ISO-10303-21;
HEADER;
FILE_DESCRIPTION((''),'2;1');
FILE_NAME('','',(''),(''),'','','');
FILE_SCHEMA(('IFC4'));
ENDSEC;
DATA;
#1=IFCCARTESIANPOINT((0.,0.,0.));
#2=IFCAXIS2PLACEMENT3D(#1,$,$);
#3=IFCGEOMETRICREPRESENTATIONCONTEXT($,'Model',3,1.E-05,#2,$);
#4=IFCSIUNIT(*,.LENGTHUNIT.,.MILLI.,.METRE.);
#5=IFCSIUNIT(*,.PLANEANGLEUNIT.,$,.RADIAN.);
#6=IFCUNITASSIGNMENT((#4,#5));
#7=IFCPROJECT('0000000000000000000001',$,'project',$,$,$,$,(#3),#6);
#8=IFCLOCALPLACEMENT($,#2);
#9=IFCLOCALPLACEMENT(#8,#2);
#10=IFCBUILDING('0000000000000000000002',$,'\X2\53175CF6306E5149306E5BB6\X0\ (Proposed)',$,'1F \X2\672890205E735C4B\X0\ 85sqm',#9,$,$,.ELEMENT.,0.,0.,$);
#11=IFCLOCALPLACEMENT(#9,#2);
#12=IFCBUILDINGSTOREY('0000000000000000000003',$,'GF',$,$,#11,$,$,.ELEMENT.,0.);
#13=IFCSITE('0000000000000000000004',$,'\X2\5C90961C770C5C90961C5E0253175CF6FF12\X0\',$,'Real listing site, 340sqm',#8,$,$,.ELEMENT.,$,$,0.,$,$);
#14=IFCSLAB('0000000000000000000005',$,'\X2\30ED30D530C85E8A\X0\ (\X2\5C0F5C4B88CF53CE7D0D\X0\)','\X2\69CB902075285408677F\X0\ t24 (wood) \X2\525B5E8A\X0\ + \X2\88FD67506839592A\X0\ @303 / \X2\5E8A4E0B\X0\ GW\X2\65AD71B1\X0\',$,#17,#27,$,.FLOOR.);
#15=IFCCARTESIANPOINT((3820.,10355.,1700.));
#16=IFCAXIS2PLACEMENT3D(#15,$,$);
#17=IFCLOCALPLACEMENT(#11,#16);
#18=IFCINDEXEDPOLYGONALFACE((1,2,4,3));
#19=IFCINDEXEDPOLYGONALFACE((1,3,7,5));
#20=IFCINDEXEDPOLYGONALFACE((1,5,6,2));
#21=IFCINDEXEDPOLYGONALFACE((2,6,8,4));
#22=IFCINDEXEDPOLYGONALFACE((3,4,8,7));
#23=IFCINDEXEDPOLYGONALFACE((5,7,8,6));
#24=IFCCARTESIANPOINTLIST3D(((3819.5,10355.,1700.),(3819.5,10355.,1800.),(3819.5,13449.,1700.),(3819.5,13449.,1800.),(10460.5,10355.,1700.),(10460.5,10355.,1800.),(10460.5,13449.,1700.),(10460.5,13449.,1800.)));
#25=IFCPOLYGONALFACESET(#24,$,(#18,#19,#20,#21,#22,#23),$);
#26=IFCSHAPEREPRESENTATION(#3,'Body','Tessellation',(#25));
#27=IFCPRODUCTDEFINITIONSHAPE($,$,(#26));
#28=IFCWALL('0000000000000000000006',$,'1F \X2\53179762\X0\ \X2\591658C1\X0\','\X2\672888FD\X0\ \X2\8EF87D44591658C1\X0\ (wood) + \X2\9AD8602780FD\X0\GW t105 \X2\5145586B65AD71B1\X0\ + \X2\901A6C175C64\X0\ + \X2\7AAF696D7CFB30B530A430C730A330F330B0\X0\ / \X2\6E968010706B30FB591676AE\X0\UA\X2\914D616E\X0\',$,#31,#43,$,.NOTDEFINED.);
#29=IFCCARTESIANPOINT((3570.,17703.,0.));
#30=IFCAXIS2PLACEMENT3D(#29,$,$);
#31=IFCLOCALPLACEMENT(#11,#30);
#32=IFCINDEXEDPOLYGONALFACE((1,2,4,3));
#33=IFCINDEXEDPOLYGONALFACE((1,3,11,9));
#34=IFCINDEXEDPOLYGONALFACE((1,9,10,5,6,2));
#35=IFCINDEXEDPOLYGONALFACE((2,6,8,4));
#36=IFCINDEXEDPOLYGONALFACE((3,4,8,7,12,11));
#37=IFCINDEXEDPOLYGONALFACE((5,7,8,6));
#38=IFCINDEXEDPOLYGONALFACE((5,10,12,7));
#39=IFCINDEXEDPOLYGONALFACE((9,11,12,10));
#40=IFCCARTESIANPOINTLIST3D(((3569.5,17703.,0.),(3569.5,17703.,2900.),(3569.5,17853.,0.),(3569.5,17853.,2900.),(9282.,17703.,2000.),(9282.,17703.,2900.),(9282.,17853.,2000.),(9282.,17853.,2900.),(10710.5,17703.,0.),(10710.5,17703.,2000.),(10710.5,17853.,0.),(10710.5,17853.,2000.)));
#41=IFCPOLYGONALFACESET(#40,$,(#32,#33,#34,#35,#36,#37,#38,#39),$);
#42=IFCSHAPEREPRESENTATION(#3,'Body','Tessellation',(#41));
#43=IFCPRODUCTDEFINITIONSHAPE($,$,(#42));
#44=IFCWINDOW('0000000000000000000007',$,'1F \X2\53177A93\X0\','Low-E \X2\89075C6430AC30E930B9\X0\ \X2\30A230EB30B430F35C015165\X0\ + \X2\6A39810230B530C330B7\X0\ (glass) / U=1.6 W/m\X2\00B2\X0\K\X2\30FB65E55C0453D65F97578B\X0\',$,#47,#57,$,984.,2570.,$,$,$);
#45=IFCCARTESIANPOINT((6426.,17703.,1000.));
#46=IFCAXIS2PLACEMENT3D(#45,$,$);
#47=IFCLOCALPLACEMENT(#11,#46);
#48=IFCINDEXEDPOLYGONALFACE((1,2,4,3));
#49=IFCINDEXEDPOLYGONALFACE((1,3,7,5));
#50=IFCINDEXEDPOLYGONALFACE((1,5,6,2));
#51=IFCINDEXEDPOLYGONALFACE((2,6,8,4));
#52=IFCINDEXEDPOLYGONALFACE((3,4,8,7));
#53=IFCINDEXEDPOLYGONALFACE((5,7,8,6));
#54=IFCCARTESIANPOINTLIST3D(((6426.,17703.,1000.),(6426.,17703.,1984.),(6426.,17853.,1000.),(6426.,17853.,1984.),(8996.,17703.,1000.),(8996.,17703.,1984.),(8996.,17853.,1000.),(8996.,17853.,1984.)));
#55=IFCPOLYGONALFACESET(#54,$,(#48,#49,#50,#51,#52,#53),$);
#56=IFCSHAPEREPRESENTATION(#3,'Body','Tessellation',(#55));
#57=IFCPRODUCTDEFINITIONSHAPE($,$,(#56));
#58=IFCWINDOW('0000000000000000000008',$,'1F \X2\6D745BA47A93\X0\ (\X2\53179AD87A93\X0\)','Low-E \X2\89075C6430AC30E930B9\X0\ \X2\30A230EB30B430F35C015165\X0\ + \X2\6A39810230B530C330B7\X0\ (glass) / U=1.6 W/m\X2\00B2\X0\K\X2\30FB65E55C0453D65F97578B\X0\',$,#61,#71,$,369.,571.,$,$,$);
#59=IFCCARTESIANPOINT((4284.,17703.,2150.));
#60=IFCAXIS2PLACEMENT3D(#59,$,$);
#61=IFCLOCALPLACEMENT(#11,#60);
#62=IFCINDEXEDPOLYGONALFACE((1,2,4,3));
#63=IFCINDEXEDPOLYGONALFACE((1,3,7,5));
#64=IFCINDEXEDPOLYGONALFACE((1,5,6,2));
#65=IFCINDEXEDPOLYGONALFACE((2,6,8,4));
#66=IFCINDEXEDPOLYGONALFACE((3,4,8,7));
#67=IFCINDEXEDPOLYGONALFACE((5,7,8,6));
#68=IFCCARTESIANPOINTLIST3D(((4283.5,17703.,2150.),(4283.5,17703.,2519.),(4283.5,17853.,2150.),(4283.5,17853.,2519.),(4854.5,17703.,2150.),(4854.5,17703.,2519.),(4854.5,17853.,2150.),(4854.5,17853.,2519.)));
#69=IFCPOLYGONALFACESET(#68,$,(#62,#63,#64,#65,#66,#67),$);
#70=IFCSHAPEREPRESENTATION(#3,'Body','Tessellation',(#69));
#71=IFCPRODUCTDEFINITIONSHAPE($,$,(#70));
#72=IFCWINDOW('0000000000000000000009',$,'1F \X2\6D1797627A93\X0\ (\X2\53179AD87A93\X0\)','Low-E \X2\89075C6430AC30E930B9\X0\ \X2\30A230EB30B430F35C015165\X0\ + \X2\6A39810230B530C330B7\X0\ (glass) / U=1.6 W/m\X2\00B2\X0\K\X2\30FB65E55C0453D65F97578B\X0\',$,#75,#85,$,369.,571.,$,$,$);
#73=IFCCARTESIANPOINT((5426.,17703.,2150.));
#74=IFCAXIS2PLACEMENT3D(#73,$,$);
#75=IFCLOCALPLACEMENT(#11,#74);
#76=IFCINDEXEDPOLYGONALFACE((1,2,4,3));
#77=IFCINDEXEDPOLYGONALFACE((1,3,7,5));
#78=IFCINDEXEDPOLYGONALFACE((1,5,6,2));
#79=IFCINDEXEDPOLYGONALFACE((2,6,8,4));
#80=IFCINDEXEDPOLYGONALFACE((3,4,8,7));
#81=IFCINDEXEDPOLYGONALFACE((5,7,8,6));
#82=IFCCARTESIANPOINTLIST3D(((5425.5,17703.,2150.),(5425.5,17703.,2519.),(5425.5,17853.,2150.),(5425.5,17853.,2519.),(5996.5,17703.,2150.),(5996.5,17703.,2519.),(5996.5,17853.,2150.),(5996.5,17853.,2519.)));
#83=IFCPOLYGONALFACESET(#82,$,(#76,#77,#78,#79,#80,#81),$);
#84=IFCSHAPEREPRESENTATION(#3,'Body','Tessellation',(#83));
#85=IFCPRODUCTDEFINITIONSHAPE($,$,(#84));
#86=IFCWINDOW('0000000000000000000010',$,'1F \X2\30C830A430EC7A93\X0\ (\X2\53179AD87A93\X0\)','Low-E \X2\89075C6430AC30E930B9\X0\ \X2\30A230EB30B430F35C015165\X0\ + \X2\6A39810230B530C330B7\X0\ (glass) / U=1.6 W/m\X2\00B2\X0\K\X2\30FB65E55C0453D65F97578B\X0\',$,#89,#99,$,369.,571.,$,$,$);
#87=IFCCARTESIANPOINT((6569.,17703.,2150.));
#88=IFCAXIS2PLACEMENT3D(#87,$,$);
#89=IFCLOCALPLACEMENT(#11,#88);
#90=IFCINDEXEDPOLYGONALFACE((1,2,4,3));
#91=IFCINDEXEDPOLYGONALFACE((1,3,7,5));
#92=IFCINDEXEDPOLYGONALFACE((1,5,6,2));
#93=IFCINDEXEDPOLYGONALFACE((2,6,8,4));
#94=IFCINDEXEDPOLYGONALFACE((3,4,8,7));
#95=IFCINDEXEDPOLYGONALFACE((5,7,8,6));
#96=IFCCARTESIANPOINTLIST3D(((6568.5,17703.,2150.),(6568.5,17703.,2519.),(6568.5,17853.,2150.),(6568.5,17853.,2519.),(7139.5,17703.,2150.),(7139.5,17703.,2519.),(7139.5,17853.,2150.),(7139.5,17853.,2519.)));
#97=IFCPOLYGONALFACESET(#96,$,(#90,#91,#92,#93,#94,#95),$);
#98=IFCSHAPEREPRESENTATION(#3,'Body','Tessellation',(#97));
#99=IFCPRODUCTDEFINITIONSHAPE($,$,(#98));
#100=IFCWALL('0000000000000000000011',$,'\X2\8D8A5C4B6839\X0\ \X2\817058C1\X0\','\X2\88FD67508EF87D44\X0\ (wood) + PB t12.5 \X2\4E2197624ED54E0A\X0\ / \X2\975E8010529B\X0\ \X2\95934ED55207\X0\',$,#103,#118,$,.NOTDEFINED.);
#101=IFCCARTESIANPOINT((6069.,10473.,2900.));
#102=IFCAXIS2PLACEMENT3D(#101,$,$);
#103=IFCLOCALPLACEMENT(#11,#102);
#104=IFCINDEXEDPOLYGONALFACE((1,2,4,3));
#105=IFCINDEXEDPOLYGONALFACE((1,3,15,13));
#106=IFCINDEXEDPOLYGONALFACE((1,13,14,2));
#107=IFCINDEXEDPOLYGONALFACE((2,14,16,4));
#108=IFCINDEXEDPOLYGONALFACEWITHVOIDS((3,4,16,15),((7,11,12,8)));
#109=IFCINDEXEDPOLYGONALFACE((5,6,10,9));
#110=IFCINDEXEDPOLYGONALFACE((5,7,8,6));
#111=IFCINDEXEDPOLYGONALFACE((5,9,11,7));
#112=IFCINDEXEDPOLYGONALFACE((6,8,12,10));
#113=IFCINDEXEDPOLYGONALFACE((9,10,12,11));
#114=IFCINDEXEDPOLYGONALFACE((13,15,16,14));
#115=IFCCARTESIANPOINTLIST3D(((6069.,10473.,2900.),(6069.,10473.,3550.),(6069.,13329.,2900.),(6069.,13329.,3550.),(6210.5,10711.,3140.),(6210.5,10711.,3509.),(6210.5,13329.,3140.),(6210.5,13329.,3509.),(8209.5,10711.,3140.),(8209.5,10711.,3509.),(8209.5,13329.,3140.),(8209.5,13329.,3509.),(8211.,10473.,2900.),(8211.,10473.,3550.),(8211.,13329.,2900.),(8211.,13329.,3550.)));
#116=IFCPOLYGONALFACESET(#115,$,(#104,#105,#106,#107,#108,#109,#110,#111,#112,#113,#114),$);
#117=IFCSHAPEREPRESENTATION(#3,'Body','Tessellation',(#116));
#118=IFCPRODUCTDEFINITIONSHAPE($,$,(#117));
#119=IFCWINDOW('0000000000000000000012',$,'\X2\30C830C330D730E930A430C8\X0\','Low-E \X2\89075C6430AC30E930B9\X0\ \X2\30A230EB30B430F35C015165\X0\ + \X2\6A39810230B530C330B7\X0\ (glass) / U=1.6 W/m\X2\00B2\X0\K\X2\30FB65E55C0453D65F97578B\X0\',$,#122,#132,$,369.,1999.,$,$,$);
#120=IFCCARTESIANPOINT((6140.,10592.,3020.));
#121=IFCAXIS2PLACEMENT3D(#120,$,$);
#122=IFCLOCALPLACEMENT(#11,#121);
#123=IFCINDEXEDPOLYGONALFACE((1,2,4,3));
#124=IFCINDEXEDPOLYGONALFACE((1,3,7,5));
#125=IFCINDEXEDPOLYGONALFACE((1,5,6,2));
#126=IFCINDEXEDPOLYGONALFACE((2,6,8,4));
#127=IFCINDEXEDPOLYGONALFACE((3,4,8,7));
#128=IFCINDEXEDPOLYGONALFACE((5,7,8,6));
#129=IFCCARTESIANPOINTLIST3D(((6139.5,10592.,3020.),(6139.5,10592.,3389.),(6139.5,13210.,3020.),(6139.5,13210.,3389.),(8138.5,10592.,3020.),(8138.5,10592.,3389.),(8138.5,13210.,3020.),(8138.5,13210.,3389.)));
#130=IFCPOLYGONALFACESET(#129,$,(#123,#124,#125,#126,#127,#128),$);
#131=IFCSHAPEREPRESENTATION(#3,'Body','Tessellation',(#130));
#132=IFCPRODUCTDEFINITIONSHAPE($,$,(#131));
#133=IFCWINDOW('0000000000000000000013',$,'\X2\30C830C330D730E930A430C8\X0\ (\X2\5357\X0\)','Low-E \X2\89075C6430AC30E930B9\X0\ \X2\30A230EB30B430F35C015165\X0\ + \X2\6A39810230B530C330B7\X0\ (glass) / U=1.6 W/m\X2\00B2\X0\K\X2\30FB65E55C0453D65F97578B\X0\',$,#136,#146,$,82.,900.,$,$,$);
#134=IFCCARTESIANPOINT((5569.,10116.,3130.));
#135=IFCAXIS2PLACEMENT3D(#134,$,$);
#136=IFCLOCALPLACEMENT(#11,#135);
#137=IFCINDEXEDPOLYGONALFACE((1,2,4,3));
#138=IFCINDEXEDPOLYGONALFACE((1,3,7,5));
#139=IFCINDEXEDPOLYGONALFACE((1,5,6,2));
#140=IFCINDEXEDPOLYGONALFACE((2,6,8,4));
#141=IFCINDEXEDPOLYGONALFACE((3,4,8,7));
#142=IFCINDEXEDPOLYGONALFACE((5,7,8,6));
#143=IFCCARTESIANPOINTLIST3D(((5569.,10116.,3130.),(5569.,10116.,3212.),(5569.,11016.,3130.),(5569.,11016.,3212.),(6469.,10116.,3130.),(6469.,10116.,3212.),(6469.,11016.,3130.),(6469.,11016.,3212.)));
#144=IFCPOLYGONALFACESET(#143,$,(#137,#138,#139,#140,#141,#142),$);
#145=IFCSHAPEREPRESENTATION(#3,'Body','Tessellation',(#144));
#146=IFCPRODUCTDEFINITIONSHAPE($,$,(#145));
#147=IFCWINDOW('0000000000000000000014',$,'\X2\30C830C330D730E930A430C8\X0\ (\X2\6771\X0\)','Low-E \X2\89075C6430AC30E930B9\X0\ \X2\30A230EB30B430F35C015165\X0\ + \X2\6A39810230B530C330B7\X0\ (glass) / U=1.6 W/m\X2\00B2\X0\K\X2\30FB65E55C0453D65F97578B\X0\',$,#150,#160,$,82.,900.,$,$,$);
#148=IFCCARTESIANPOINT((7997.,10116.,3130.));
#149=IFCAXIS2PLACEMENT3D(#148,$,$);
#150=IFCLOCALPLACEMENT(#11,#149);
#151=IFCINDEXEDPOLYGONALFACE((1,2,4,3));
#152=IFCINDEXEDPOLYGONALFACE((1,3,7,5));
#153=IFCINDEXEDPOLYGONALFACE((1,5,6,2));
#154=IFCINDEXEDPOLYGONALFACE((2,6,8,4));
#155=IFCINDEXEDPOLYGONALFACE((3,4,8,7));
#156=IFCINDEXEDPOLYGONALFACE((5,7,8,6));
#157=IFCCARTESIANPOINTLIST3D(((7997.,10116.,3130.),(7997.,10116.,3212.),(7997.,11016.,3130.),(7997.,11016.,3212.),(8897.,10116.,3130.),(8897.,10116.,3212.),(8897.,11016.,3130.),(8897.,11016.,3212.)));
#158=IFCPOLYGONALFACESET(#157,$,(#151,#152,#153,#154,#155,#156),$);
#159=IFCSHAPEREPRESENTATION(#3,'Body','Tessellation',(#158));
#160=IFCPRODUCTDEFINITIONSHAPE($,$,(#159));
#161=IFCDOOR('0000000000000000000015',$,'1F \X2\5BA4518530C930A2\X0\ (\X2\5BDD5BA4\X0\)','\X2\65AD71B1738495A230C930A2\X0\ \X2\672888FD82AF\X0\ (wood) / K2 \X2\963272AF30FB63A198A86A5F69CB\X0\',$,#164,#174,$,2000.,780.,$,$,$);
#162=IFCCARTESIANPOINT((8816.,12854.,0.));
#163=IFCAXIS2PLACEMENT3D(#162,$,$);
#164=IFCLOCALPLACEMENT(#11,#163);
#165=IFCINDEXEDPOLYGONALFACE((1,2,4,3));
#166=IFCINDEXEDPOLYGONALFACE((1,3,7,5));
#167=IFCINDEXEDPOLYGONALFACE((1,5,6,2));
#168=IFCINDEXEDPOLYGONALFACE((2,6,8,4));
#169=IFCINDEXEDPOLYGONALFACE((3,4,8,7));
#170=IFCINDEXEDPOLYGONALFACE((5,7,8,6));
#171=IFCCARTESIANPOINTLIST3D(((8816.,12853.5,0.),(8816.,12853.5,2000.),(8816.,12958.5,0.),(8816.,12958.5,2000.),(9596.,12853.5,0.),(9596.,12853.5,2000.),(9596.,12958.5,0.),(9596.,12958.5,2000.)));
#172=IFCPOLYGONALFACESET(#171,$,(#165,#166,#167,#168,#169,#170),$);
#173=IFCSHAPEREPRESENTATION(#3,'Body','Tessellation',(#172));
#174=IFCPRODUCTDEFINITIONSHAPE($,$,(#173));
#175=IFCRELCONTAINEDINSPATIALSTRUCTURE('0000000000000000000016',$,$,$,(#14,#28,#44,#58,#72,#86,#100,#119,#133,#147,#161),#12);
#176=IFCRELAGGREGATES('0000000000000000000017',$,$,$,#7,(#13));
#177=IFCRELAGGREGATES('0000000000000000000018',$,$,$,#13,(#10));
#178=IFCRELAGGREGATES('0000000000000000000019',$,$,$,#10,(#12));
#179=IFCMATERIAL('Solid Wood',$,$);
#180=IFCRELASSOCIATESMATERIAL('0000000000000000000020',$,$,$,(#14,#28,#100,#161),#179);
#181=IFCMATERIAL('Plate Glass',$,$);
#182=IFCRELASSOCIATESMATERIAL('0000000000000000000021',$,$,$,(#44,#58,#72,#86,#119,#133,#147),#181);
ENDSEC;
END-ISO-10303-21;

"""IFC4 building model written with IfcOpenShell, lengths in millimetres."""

from ifc_helpers import new_model, si_unit, frame, frame_2d, origin, place, context, project, spatial, rectangle, extrude, material, element, fill, save


model = new_model("IFC4")

# Units and contexts
model_context = context("Model", 3, precision=1e-05, world=origin())
ifc_project = project(units=[si_unit("LENGTHUNIT", "METRE", prefix="MILLI"), si_unit("PLANEANGLEUNIT", "RADIAN")], contexts=[model_context])

# Site, building, storey
site_placement = place(None, origin())
site = spatial("IfcSite", under=ifc_project, at=site_placement, Name="岐阜県岐阜市北島２", ObjectType="Real listing site, 340sqm", CompositionType="ELEMENT", RefElevation=0.0)
building_placement = place(site_placement, origin())
building = spatial("IfcBuilding", under=site, at=building_placement, Name="北島の光の家 (Proposed)", ObjectType="1F 木造平屋 85sqm", CompositionType="ELEMENT", ElevationOfRefHeight=0.0, ElevationOfTerrain=0.0)
storey_placement = place(building_placement, origin())
storey = spatial("IfcBuildingStorey", under=building, at=storey_placement, Name="GF", CompositionType="ELEMENT", Elevation=0.0)

# Slab
ifc_material_1 = material(Name="Solid Wood")
slab_placement = place(storey_placement, frame((3820.0, 10355.0, 1700.0)))
element("IfcSlab", 1, at=slab_placement, inside=storey, material=ifc_material_1, Name="ロフト床 (小屋裏収納)", Description="構造用合板 t24 (wood) 剛床 + 製材根太 @303 / 床下 GW断熱", PredefinedType="FLOOR", context=model_context, shape_type="SweptSolid", body=[
    extrude(rectangle(XDim=6641.0, YDim=3094.0, at=frame_2d((3320.0, 1547.0))), frame((3820.0, 10355.0, 1700.0)), (0.0, 0.0, 1.0), 100.0),
])

# Wall, openings, windows
wall_1_placement = place(storey_placement, frame((3570.0, 17703.0, 0.0)))
wall_1 = element("IfcWall", 2, at=wall_1_placement, inside=storey, material=ifc_material_1, Name="1F 北面 外壁", Description="木製 軸組外壁 (wood) + 高性能GW t105 充填断熱 + 通気層 + 窯業系サイディング / 準耐火・外皮UA配慮", PredefinedType="NOTDEFINED", context=model_context, shape_type="SweptSolid", body=[
    extrude(rectangle(XDim=7141.0, YDim=150.0, at=frame_2d((3570.0, 75.0))), frame((3570.0, 17703.0, 0.0)), (0.0, 0.0, 1.0), 2900.0),
])
opening_1_placement = place(storey_placement, frame((6426.0, 17703.0, 1000.0)))
opening_1 = element("IfcOpeningElement", 3, at=opening_1_placement, cuts=wall_1, PredefinedType="NOTDEFINED", context=model_context, shape_type="SweptSolid", body=[
    extrude(rectangle(XDim=2570.0, YDim=150.0, at=frame_2d((1285.0, 75.0))), frame((6426.0, 17703.0, 1000.0)), (0.0, 0.0, 1.0), 984.0),
])
opening_2_placement = place(storey_placement, frame((4284.0, 17703.0, 2150.0)))
opening_2 = element("IfcOpeningElement", 4, at=opening_2_placement, cuts=wall_1, PredefinedType="NOTDEFINED", context=model_context, shape_type="SweptSolid", body=[
    extrude(rectangle(XDim=571.0, YDim=150.0, at=frame_2d((285.0, 75.0))), frame((4284.0, 17703.0, 2150.0)), (0.0, 0.0, 1.0), 369.0),
])
opening_3_placement = place(storey_placement, frame((5426.0, 17703.0, 2150.0)))
opening_3 = element("IfcOpeningElement", 5, at=opening_3_placement, cuts=wall_1, PredefinedType="NOTDEFINED", context=model_context, shape_type="SweptSolid", body=[
    extrude(rectangle(XDim=571.0, YDim=150.0, at=frame_2d((285.0, 75.0))), frame((5426.0, 17703.0, 2150.0)), (0.0, 0.0, 1.0), 369.0),
])
opening_4_placement = place(storey_placement, frame((6569.0, 17703.0, 2150.0)))
opening_4 = element("IfcOpeningElement", 6, at=opening_4_placement, cuts=wall_1, PredefinedType="NOTDEFINED", context=model_context, shape_type="SweptSolid", body=[
    extrude(rectangle(XDim=571.0, YDim=150.0, at=frame_2d((285.0, 75.0))), frame((6569.0, 17703.0, 2150.0)), (0.0, 0.0, 1.0), 369.0),
])
ifc_material_2 = material(Name="Plate Glass")
window_1_placement = place(storey_placement, frame((6426.0, 17703.0, 1000.0)))
window_1 = element("IfcWindow", 7, at=window_1_placement, inside=storey, material=ifc_material_2, Name="1F 北窓", Description="Low-E 複層ガラス アルゴン封入 + 樹脂サッシ (glass) / U=1.6 W/m²K・日射取得型", OverallHeight=984.0, OverallWidth=2570.0, context=model_context, shape_type="SweptSolid", body=[
    extrude(rectangle(XDim=2570.0, YDim=150.0, at=frame_2d((1285.0, 75.0))), frame((6426.0, 17703.0, 1000.0)), (0.0, 0.0, 1.0), 984.0),
])
fill(opening_1, window_1)
window_2_placement = place(storey_placement, frame((4284.0, 17703.0, 2150.0)))
window_2 = element("IfcWindow", 8, at=window_2_placement, inside=storey, material=ifc_material_2, Name="1F 浴室窓 (北高窓)", Description="Low-E 複層ガラス アルゴン封入 + 樹脂サッシ (glass) / U=1.6 W/m²K・日射取得型", OverallHeight=369.0, OverallWidth=571.0, context=model_context, shape_type="SweptSolid", body=[
    extrude(rectangle(XDim=571.0, YDim=150.0, at=frame_2d((285.0, 75.0))), frame((4284.0, 17703.0, 2150.0)), (0.0, 0.0, 1.0), 369.0),
])
fill(opening_2, window_2)
window_3_placement = place(storey_placement, frame((5426.0, 17703.0, 2150.0)))
window_3 = element("IfcWindow", 9, at=window_3_placement, inside=storey, material=ifc_material_2, Name="1F 洗面窓 (北高窓)", Description="Low-E 複層ガラス アルゴン封入 + 樹脂サッシ (glass) / U=1.6 W/m²K・日射取得型", OverallHeight=369.0, OverallWidth=571.0, context=model_context, shape_type="SweptSolid", body=[
    extrude(rectangle(XDim=571.0, YDim=150.0, at=frame_2d((285.0, 75.0))), frame((5426.0, 17703.0, 2150.0)), (0.0, 0.0, 1.0), 369.0),
])
fill(opening_3, window_3)
window_4_placement = place(storey_placement, frame((6569.0, 17703.0, 2150.0)))
window_4 = element("IfcWindow", 10, at=window_4_placement, inside=storey, material=ifc_material_2, Name="1F トイレ窓 (北高窓)", Description="Low-E 複層ガラス アルゴン封入 + 樹脂サッシ (glass) / U=1.6 W/m²K・日射取得型", OverallHeight=369.0, OverallWidth=571.0, context=model_context, shape_type="SweptSolid", body=[
    extrude(rectangle(XDim=571.0, YDim=150.0, at=frame_2d((285.0, 75.0))), frame((6569.0, 17703.0, 2150.0)), (0.0, 0.0, 1.0), 369.0),
])
fill(opening_4, window_4)

# Wall, openings, windows
wall_2_placement = place(storey_placement, frame((6069.0, 10473.0, 2900.0)))
wall_2 = element("IfcWall", 11, at=wall_2_placement, inside=storey, material=ifc_material_1, Name="越屋根 腰壁", Description="製材軸組 (wood) + PB t12.5 両面仕上 / 非耐力 間仕切", PredefinedType="NOTDEFINED", context=model_context, shape_type="SweptSolid", body=[
    extrude(rectangle(XDim=2142.0, YDim=2856.0, at=frame_2d((1071.0, 1428.0))), frame((6069.0, 10473.0, 2900.0)), (0.0, 0.0, 1.0), 650.0),
])
opening_5_placement = place(storey_placement, frame((6140.0, 10592.0, 3020.0)))
opening_5 = element("IfcOpeningElement", 12, at=opening_5_placement, cuts=wall_2, PredefinedType="NOTDEFINED", context=model_context, shape_type="SweptSolid", body=[
    extrude(rectangle(XDim=1999.0, YDim=2618.0, at=frame_2d((999.0, 1309.0))), frame((6140.0, 10592.0, 3020.0)), (0.0, 0.0, 1.0), 369.0),
])
opening_6_placement = place(storey_placement, frame((5569.0, 10116.0, 3130.0)))
opening_6 = element("IfcOpeningElement", 13, at=opening_6_placement, cuts=wall_2, PredefinedType="NOTDEFINED", context=model_context, shape_type="SweptSolid", body=[
    extrude(rectangle(XDim=900.0, YDim=900.0, at=frame_2d((450.0, 450.0))), frame((5569.0, 10116.0, 3130.0)), (0.0, 0.0, 1.0), 82.0),
])
opening_7_placement = place(storey_placement, frame((7997.0, 10116.0, 3130.0)))
opening_7 = element("IfcOpeningElement", 14, at=opening_7_placement, cuts=wall_2, PredefinedType="NOTDEFINED", context=model_context, shape_type="SweptSolid", body=[
    extrude(rectangle(XDim=900.0, YDim=900.0, at=frame_2d((450.0, 450.0))), frame((7997.0, 10116.0, 3130.0)), (0.0, 0.0, 1.0), 82.0),
])
window_5_placement = place(storey_placement, frame((6140.0, 10592.0, 3020.0)))
window_5 = element("IfcWindow", 15, at=window_5_placement, inside=storey, material=ifc_material_2, Name="トップライト", Description="Low-E 複層ガラス アルゴン封入 + 樹脂サッシ (glass) / U=1.6 W/m²K・日射取得型", OverallHeight=369.0, OverallWidth=1999.0, context=model_context, shape_type="SweptSolid", body=[
    extrude(rectangle(XDim=1999.0, YDim=2618.0, at=frame_2d((999.0, 1309.0))), frame((6140.0, 10592.0, 3020.0)), (0.0, 0.0, 1.0), 369.0),
])
fill(opening_5, window_5)
window_6_placement = place(storey_placement, frame((5569.0, 10116.0, 3130.0)))
window_6 = element("IfcWindow", 16, at=window_6_placement, inside=storey, material=ifc_material_2, Name="トップライト (南)", Description="Low-E 複層ガラス アルゴン封入 + 樹脂サッシ (glass) / U=1.6 W/m²K・日射取得型", OverallHeight=82.0, OverallWidth=900.0, context=model_context, shape_type="SweptSolid", body=[
    extrude(rectangle(XDim=900.0, YDim=900.0, at=frame_2d((450.0, 450.0))), frame((5569.0, 10116.0, 3130.0)), (0.0, 0.0, 1.0), 82.0),
])
fill(opening_6, window_6)
window_7_placement = place(storey_placement, frame((7997.0, 10116.0, 3130.0)))
window_7 = element("IfcWindow", 17, at=window_7_placement, inside=storey, material=ifc_material_2, Name="トップライト (東)", Description="Low-E 複層ガラス アルゴン封入 + 樹脂サッシ (glass) / U=1.6 W/m²K・日射取得型", OverallHeight=82.0, OverallWidth=900.0, context=model_context, shape_type="SweptSolid", body=[
    extrude(rectangle(XDim=900.0, YDim=900.0, at=frame_2d((450.0, 450.0))), frame((7997.0, 10116.0, 3130.0)), (0.0, 0.0, 1.0), 82.0),
])
fill(opening_7, window_7)

# Door
door_1_placement = place(storey_placement, frame((8816.0, 12854.0, 0.0)))
element("IfcDoor", 18, at=door_1_placement, inside=storey, material=ifc_material_1, Name="1F 室内ドア (寝室)", Description="断熱玄関ドア 木製芯 (wood) / K2 防犯・採風機構", OverallHeight=2000.0, OverallWidth=780.0, context=model_context, shape_type="SweptSolid", body=[
    extrude(rectangle(XDim=780.0, YDim=105.0, at=frame_2d((390.0, 52.0))), frame((8816.0, 12854.0, 0.0)), (0.0, 0.0, 1.0), 2000.0),
])

save(model, "model.ifc")
